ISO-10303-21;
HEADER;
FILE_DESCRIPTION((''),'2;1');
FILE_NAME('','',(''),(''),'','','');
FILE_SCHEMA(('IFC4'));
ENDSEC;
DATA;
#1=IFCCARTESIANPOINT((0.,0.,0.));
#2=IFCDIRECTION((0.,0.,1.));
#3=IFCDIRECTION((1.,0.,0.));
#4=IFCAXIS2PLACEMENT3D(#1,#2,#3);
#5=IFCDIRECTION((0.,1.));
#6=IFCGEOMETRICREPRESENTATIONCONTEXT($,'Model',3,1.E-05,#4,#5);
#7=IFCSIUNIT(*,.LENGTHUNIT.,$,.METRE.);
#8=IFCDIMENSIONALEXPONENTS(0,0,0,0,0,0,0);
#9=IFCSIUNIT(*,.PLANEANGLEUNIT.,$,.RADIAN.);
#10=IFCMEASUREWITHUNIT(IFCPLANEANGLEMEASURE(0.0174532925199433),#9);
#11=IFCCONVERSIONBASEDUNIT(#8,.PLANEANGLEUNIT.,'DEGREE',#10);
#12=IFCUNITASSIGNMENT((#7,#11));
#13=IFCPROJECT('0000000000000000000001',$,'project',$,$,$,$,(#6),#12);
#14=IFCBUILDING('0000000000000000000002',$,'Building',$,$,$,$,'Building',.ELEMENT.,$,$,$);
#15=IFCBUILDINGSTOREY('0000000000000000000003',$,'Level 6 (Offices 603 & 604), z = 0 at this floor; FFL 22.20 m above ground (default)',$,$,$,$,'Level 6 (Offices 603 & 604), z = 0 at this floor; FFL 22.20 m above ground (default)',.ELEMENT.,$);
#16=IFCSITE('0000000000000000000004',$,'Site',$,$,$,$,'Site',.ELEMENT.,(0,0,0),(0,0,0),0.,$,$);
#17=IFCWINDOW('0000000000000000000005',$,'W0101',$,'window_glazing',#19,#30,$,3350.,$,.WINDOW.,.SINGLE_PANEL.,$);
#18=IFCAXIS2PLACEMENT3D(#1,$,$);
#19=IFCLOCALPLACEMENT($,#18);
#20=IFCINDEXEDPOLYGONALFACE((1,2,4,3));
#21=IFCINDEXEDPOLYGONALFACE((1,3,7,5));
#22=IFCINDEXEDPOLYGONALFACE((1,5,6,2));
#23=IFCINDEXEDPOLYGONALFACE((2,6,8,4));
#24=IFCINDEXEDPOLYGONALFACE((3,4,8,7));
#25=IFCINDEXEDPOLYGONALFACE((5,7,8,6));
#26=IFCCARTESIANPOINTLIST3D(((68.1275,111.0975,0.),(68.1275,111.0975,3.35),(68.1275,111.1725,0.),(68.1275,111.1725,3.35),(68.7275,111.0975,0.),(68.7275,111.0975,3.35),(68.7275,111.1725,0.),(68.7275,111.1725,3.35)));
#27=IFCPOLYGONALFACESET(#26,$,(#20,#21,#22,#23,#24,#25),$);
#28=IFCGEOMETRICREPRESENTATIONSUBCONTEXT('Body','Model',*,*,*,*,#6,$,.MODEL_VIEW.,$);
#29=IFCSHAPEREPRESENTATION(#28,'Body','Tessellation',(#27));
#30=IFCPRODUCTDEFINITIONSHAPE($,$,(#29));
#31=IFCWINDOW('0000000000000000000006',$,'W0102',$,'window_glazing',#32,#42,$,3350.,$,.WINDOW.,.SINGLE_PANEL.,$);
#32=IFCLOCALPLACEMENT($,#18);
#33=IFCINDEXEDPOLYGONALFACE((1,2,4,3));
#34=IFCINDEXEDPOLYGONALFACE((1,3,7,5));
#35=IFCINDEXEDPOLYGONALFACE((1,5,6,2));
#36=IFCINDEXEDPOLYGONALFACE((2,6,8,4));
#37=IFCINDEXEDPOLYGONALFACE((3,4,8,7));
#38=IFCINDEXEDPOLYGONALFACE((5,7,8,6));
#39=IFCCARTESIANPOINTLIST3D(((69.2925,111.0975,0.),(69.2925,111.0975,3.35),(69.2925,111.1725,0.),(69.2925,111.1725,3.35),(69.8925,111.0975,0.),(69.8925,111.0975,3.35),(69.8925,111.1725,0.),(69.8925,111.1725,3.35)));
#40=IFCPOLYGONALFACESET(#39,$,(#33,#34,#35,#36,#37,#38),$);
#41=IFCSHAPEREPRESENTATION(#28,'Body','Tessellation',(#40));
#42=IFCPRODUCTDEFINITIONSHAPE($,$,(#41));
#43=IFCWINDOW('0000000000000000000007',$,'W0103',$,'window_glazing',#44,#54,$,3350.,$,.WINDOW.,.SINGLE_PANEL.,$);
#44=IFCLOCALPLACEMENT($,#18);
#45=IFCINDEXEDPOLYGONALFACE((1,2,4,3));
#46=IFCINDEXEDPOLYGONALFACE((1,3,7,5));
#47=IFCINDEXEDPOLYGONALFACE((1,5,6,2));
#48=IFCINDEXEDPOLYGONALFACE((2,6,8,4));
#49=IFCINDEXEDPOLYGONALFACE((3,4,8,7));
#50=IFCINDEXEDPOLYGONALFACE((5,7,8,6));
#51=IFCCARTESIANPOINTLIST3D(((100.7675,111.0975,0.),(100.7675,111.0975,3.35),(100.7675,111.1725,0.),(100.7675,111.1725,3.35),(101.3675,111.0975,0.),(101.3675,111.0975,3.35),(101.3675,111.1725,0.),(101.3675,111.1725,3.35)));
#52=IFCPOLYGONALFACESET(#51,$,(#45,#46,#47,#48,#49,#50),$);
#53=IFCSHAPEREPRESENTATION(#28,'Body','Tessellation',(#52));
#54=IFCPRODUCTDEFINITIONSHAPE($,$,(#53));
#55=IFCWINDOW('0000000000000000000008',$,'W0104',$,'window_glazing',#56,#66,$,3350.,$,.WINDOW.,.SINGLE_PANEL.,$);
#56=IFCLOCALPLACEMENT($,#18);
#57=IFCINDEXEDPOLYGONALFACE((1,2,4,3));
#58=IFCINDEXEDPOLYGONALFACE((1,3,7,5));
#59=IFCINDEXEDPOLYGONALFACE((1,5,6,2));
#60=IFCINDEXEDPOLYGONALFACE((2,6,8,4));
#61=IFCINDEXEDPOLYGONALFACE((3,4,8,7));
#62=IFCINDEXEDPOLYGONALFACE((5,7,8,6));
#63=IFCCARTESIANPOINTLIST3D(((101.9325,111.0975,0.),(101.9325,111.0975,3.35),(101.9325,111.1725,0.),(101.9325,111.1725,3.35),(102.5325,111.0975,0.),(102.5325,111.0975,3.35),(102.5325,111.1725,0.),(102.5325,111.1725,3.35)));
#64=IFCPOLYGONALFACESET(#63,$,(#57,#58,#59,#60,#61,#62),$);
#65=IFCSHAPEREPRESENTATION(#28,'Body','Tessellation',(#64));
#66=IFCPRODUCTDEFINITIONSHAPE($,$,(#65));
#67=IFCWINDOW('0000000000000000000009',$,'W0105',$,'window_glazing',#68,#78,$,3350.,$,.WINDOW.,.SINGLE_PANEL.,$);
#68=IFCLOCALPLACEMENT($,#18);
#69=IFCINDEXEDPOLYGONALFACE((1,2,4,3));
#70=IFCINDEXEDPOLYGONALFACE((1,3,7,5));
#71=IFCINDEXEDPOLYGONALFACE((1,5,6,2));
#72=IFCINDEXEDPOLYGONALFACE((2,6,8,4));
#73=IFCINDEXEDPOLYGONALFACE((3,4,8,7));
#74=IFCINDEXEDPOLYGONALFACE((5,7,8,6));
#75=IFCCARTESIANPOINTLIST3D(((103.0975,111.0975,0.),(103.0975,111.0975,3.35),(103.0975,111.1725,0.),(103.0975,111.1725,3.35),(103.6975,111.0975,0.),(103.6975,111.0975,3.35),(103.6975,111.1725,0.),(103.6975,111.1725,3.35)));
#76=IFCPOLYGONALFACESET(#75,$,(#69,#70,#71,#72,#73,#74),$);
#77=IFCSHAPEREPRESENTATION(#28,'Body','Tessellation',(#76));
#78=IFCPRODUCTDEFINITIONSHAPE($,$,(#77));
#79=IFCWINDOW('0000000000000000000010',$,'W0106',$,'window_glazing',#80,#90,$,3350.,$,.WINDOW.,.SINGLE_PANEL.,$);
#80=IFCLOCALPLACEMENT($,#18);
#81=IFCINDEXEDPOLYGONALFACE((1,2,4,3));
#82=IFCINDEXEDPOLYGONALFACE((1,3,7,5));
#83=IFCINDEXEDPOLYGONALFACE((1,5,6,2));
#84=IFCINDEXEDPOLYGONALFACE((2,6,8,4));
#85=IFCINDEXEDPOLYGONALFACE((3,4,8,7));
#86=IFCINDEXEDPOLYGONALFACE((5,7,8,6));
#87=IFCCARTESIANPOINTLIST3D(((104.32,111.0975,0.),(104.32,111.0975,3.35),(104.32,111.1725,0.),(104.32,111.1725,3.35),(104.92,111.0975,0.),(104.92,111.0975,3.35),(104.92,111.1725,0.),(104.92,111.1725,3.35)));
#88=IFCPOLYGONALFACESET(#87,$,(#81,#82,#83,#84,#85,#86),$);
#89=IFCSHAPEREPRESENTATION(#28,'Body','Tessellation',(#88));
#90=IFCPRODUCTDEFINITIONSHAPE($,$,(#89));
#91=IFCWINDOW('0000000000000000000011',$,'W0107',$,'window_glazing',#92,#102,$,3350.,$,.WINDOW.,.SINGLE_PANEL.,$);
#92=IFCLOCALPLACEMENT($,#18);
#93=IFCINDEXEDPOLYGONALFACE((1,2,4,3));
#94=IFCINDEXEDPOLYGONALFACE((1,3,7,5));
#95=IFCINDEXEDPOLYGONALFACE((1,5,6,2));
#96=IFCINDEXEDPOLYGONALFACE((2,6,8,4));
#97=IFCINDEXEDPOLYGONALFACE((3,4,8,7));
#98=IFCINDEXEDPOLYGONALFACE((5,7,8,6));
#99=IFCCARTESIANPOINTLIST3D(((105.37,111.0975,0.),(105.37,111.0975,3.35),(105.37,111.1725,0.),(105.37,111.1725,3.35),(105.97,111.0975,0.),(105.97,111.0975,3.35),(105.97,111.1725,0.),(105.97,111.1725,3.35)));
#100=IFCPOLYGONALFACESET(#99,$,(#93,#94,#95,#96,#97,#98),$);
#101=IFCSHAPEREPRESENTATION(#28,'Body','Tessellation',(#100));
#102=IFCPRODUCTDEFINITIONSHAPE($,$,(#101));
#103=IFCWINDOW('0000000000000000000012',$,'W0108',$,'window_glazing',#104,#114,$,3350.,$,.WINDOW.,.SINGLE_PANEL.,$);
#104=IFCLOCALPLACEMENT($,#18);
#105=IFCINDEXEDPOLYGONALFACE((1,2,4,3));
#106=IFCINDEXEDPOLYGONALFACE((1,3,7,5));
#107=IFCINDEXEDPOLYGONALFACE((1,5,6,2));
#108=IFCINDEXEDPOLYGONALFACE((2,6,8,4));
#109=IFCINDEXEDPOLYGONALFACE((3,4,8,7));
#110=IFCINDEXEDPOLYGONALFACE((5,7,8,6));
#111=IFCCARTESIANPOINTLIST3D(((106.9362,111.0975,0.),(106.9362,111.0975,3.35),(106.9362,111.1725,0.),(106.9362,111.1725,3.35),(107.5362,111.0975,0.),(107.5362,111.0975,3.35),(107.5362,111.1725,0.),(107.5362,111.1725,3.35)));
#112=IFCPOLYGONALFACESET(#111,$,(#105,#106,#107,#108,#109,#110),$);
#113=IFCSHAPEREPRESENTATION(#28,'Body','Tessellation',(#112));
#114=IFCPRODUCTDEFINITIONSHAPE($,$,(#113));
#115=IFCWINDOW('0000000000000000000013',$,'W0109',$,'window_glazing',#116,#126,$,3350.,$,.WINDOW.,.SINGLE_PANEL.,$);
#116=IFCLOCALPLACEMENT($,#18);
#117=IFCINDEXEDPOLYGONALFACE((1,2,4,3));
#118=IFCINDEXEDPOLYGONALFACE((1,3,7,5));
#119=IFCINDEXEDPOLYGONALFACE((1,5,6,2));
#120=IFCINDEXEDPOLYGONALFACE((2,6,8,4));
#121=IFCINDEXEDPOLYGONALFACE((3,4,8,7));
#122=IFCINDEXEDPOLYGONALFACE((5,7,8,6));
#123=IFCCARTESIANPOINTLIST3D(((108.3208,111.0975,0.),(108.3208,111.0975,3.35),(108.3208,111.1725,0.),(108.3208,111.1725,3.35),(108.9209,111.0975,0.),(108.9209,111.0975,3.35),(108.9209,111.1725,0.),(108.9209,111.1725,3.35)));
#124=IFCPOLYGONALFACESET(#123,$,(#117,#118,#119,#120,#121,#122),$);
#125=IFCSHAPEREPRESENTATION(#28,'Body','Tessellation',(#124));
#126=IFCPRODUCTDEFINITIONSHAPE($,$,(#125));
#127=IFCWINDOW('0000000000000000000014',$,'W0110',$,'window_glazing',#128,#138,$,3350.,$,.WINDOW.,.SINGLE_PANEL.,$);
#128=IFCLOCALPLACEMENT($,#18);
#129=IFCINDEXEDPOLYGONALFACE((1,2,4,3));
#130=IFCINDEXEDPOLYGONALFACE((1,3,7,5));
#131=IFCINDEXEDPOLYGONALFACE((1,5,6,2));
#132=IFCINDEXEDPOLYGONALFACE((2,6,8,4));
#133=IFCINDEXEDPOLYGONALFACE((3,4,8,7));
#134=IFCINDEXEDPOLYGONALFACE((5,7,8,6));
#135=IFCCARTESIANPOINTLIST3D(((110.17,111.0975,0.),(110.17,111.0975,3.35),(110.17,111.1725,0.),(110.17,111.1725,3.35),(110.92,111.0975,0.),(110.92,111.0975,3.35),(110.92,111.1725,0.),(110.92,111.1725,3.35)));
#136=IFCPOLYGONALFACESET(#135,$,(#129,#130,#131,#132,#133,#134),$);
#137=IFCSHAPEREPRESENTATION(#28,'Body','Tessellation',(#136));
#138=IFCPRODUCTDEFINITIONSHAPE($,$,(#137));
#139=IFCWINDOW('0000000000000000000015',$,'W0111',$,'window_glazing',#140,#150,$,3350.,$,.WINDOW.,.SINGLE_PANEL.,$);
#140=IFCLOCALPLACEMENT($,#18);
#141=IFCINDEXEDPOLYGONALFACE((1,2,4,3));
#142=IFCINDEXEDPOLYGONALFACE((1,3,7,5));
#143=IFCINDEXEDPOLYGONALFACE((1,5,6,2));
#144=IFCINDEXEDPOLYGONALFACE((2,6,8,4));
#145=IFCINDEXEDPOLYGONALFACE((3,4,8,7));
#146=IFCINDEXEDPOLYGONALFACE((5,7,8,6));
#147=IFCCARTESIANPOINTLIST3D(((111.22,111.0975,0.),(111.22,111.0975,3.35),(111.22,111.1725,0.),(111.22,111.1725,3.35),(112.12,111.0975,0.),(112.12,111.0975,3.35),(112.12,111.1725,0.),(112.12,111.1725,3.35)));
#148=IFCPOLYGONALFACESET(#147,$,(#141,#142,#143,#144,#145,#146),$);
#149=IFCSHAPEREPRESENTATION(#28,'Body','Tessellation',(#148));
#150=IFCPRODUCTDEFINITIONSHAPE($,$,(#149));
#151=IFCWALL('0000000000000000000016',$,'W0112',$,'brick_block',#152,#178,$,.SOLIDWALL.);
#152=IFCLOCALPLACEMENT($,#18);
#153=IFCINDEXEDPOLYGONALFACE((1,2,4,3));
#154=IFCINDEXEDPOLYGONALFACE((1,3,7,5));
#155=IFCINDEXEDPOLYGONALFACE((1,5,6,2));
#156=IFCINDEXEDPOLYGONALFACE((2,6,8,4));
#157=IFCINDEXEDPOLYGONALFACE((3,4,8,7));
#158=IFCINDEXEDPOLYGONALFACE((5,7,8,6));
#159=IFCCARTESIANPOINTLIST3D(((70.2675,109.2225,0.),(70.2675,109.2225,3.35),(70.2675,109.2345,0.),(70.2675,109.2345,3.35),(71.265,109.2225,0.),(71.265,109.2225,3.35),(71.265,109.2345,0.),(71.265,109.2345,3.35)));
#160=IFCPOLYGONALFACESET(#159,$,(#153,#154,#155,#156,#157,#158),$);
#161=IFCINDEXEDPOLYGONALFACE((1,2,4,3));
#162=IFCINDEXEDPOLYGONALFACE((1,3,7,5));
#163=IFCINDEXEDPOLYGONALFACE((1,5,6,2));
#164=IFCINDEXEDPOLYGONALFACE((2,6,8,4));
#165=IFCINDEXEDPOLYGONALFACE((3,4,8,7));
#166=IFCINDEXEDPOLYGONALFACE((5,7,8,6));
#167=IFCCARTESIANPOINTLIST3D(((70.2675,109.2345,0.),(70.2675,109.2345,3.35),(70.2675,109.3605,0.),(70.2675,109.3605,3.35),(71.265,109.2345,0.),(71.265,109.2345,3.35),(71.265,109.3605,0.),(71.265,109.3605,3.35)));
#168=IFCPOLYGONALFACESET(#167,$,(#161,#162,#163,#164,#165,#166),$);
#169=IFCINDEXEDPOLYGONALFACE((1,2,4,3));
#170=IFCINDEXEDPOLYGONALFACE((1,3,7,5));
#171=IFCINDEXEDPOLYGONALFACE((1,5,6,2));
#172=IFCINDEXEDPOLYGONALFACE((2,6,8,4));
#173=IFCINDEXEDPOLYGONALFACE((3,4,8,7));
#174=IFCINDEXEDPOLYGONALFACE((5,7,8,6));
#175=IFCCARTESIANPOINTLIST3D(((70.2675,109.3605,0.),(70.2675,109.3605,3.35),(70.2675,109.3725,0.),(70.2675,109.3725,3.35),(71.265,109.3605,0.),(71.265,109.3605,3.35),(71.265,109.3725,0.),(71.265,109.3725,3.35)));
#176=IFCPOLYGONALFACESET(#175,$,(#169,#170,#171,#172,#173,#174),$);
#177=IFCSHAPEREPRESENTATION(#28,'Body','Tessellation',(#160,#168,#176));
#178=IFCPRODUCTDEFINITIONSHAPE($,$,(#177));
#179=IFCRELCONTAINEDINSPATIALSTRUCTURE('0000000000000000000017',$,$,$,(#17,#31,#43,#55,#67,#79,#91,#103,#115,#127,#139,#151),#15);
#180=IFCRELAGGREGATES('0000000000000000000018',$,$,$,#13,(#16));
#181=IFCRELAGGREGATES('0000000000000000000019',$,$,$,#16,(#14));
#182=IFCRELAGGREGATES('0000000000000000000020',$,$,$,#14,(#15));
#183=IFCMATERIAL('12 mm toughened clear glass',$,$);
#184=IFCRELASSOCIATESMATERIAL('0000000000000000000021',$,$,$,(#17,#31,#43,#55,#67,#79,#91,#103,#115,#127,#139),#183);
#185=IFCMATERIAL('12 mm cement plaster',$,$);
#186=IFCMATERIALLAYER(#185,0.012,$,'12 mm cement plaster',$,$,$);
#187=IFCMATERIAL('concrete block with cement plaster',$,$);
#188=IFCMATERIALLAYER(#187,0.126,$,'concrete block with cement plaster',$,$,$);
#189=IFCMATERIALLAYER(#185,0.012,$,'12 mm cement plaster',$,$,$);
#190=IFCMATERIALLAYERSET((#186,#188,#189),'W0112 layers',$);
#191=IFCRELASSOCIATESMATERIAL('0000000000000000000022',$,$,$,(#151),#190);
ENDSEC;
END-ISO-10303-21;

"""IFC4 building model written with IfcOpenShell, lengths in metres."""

from ifc_helpers import new_model, entity, si_unit, converted_unit, direction, frame, frame_2d, origin_with_axes, origin_2d_with_axis, place, context, subcontext, project, spatial, rectangle, extrude, material, layer, layer_set, layer_usage, element, save


model = new_model("IFC4")

# Units and contexts
model_context = context("Model", 3, precision=1e-05, world=origin_with_axes(), true_north=direction((0.0, 1.0)))
body_context = subcontext(model_context, "Body", "Model", "MODEL_VIEW")
ifc_project = project(units=[si_unit("LENGTHUNIT", "METRE"), converted_unit("PLANEANGLEUNIT", "DEGREE", entity("IfcPlaneAngleMeasure", 0.0174532925199433), si_unit("PLANEANGLEUNIT", "RADIAN"), dimensions=[0, 0, 0, 0, 0, 0, 0])], contexts=[model_context])

# Site, building, storey
site = spatial("IfcSite", under=ifc_project, Name="Site", LongName="Site", CompositionType="ELEMENT", RefLatitude=(0, 0, 0), RefLongitude=(0, 0, 0), RefElevation=0.0)
building = spatial("IfcBuilding", under=site, Name="Building", LongName="Building", CompositionType="ELEMENT")
storey = spatial("IfcBuildingStorey", under=building, Name="Level 6 (Offices 603 & 604), z = 0 at this floor; FFL 22.20 m above ground (default)", LongName="Level 6 (Offices 603 & 604), z = 0 at this floor; FFL 22.20 m above ground (default)", CompositionType="ELEMENT")

# Windows
ifc_material_1 = material(Name="12 mm toughened clear glass")
placement = place(None, origin_with_axes())
element("IfcWindow", 1, at=placement, inside=storey, material=ifc_material_1, Name="W0101", ObjectType="window_glazing", OverallHeight=3350.0, PartitioningType="SINGLE_PANEL", PredefinedType="WINDOW", context=body_context, shape_type="SweptSolid", body=[
    extrude(rectangle(XDim=0.6, YDim=0.075, at=frame_2d((0.0, 0.0), x_axis=(1.0, 0.0))), frame((68.4275, 111.135, 0.0), z_axis=(0.0, 0.0, 1.0), x_axis=(1.0, 0.0, 0.0)), (0.0, 0.0, 1.0), 3.35),
])
element("IfcWindow", 2, at=placement, inside=storey, material=ifc_material_1, Name="W0102", ObjectType="window_glazing", OverallHeight=3350.0, PartitioningType="SINGLE_PANEL", PredefinedType="WINDOW", context=body_context, shape_type="SweptSolid", body=[
    extrude(rectangle(XDim=0.6, YDim=0.075, at=frame_2d((0.0, 0.0), x_axis=(1.0, 0.0))), frame((69.5925, 111.135, 0.0), z_axis=(0.0, 0.0, 1.0), x_axis=(1.0, 0.0, 0.0)), (0.0, 0.0, 1.0), 3.35),
])
element("IfcWindow", 3, at=placement, inside=storey, material=ifc_material_1, Name="W0103", ObjectType="window_glazing", OverallHeight=3350.0, PartitioningType="SINGLE_PANEL", PredefinedType="WINDOW", context=body_context, shape_type="SweptSolid", body=[
    extrude(rectangle(XDim=0.6, YDim=0.075, at=frame_2d((0.0, 0.0), x_axis=(1.0, 0.0))), frame((101.0675, 111.135, 0.0), z_axis=(0.0, 0.0, 1.0), x_axis=(1.0, 0.0, 0.0)), (0.0, 0.0, 1.0), 3.35),
])
element("IfcWindow", 4, at=placement, inside=storey, material=ifc_material_1, Name="W0104", ObjectType="window_glazing", OverallHeight=3350.0, PartitioningType="SINGLE_PANEL", PredefinedType="WINDOW", context=body_context, shape_type="SweptSolid", body=[
    extrude(rectangle(XDim=0.6, YDim=0.075, at=frame_2d((0.0, 0.0), x_axis=(1.0, 0.0))), frame((102.2325, 111.135, 0.0), z_axis=(0.0, 0.0, 1.0), x_axis=(1.0, 0.0, 0.0)), (0.0, 0.0, 1.0), 3.35),
])
element("IfcWindow", 5, at=placement, inside=storey, material=ifc_material_1, Name="W0105", ObjectType="window_glazing", OverallHeight=3350.0, PartitioningType="SINGLE_PANEL", PredefinedType="WINDOW", context=body_context, shape_type="SweptSolid", body=[
    extrude(rectangle(XDim=0.6, YDim=0.075, at=frame_2d((0.0, 0.0), x_axis=(1.0, 0.0))), frame((103.3975, 111.135, 0.0), z_axis=(0.0, 0.0, 1.0), x_axis=(1.0, 0.0, 0.0)), (0.0, 0.0, 1.0), 3.35),
])
element("IfcWindow", 6, at=placement, inside=storey, material=ifc_material_1, Name="W0106", ObjectType="window_glazing", OverallHeight=3350.0, PartitioningType="SINGLE_PANEL", PredefinedType="WINDOW", context=body_context, shape_type="SweptSolid", body=[
    extrude(rectangle(XDim=0.6, YDim=0.075, at=frame_2d((0.0, 0.0), x_axis=(1.0, 0.0))), frame((104.62, 111.135, 0.0), z_axis=(0.0, 0.0, 1.0), x_axis=(1.0, 0.0, 0.0)), (0.0, 0.0, 1.0), 3.35),
])
element("IfcWindow", 7, at=placement, inside=storey, material=ifc_material_1, Name="W0107", ObjectType="window_glazing", OverallHeight=3350.0, PartitioningType="SINGLE_PANEL", PredefinedType="WINDOW", context=body_context, shape_type="SweptSolid", body=[
    extrude(rectangle(XDim=0.6, YDim=0.075, at=frame_2d((0.0, 0.0), x_axis=(1.0, 0.0))), frame((105.67, 111.135, 0.0), z_axis=(0.0, 0.0, 1.0), x_axis=(1.0, 0.0, 0.0)), (0.0, 0.0, 1.0), 3.35),
])
element("IfcWindow", 8, at=placement, inside=storey, material=ifc_material_1, Name="W0108", ObjectType="window_glazing", OverallHeight=3350.0, PartitioningType="SINGLE_PANEL", PredefinedType="WINDOW", context=body_context, shape_type="SweptSolid", body=[
    extrude(rectangle(XDim=0.6, YDim=0.075, at=frame_2d((0.0, 0.0), x_axis=(1.0, 0.0))), frame((107.2362, 111.135, 0.0), z_axis=(0.0, 0.0, 1.0), x_axis=(1.0, 0.0, 0.0)), (0.0, 0.0, 1.0), 3.35),
])
element("IfcWindow", 9, at=placement, inside=storey, material=ifc_material_1, Name="W0109", ObjectType="window_glazing", OverallHeight=3350.0, PartitioningType="SINGLE_PANEL", PredefinedType="WINDOW", context=body_context, shape_type="SweptSolid", body=[
    extrude(rectangle(XDim=0.6001, YDim=0.075, at=frame_2d((0.0, 0.0), x_axis=(1.0, 0.0))), frame((108.6209, 111.135, 0.0), z_axis=(0.0, 0.0, 1.0), x_axis=(1.0, 0.0, 0.0)), (0.0, 0.0, 1.0), 3.35),
])
element("IfcWindow", 10, at=placement, inside=storey, material=ifc_material_1, Name="W0110", ObjectType="window_glazing", OverallHeight=3350.0, PartitioningType="SINGLE_PANEL", PredefinedType="WINDOW", context=body_context, shape_type="SweptSolid", body=[
    extrude(rectangle(XDim=0.75, YDim=0.075, at=frame_2d((0.0, 0.0), x_axis=(1.0, 0.0))), frame((110.545, 111.135, 0.0), z_axis=(0.0, 0.0, 1.0), x_axis=(1.0, 0.0, 0.0)), (0.0, 0.0, 1.0), 3.35),
])
element("IfcWindow", 11, at=placement, inside=storey, material=ifc_material_1, Name="W0111", ObjectType="window_glazing", OverallHeight=3350.0, PartitioningType="SINGLE_PANEL", PredefinedType="WINDOW", context=body_context, shape_type="SweptSolid", body=[
    extrude(rectangle(XDim=0.9, YDim=0.075, at=frame_2d((0.0, 0.0), x_axis=(1.0, 0.0))), frame((111.67, 111.135, 0.0), z_axis=(0.0, 0.0, 1.0), x_axis=(1.0, 0.0, 0.0)), (0.0, 0.0, 1.0), 3.35),
])

# Wall
ifc_material_2 = material(Name="12 mm cement plaster")
ifc_layer_1 = layer(ifc_material_2, 0.012, Name="12 mm cement plaster")
ifc_material_3 = material(Name="concrete block with cement plaster")
ifc_layer_2 = layer(ifc_material_3, 0.126, Name="concrete block with cement plaster")
ifc_layer_3 = layer(ifc_material_2, 0.012, Name="12 mm cement plaster")
ifc_layer_set_1 = layer_set([ifc_layer_1, ifc_layer_2, ifc_layer_3], Name="W0112 layers")
ifc_layer_usage_1 = layer_usage(ifc_layer_set_1, "AXIS2", "POSITIVE", -0.075)
element("IfcWall", 12, at=placement, inside=storey, material=ifc_layer_usage_1, Name="W0112", ObjectType="brick_block", PredefinedType="SOLIDWALL", context=body_context, shape_type="SweptSolid", body=[
    extrude(rectangle(XDim=0.9975, YDim=0.012, at=origin_2d_with_axis()), frame((70.7662, 109.2285, 0.0), z_axis=(0.0, 0.0, 1.0), x_axis=(1.0, 0.0, 0.0)), (0.0, 0.0, 1.0), 3.35),
    extrude(rectangle(XDim=0.9975, YDim=0.126, at=frame_2d((0.0, 0.069), x_axis=(1.0, 0.0))), frame((70.7662, 109.2285, 0.0), z_axis=(0.0, 0.0, 1.0), x_axis=(1.0, 0.0, 0.0)), (0.0, 0.0, 1.0), 3.35),
    extrude(rectangle(XDim=0.9975, YDim=0.012, at=frame_2d((0.0, 0.138), x_axis=(1.0, 0.0))), frame((70.7662, 109.2285, 0.0), z_axis=(0.0, 0.0, 1.0), x_axis=(1.0, 0.0, 0.0)), (0.0, 0.0, 1.0), 3.35),
])

save(model, "model.ifc")
